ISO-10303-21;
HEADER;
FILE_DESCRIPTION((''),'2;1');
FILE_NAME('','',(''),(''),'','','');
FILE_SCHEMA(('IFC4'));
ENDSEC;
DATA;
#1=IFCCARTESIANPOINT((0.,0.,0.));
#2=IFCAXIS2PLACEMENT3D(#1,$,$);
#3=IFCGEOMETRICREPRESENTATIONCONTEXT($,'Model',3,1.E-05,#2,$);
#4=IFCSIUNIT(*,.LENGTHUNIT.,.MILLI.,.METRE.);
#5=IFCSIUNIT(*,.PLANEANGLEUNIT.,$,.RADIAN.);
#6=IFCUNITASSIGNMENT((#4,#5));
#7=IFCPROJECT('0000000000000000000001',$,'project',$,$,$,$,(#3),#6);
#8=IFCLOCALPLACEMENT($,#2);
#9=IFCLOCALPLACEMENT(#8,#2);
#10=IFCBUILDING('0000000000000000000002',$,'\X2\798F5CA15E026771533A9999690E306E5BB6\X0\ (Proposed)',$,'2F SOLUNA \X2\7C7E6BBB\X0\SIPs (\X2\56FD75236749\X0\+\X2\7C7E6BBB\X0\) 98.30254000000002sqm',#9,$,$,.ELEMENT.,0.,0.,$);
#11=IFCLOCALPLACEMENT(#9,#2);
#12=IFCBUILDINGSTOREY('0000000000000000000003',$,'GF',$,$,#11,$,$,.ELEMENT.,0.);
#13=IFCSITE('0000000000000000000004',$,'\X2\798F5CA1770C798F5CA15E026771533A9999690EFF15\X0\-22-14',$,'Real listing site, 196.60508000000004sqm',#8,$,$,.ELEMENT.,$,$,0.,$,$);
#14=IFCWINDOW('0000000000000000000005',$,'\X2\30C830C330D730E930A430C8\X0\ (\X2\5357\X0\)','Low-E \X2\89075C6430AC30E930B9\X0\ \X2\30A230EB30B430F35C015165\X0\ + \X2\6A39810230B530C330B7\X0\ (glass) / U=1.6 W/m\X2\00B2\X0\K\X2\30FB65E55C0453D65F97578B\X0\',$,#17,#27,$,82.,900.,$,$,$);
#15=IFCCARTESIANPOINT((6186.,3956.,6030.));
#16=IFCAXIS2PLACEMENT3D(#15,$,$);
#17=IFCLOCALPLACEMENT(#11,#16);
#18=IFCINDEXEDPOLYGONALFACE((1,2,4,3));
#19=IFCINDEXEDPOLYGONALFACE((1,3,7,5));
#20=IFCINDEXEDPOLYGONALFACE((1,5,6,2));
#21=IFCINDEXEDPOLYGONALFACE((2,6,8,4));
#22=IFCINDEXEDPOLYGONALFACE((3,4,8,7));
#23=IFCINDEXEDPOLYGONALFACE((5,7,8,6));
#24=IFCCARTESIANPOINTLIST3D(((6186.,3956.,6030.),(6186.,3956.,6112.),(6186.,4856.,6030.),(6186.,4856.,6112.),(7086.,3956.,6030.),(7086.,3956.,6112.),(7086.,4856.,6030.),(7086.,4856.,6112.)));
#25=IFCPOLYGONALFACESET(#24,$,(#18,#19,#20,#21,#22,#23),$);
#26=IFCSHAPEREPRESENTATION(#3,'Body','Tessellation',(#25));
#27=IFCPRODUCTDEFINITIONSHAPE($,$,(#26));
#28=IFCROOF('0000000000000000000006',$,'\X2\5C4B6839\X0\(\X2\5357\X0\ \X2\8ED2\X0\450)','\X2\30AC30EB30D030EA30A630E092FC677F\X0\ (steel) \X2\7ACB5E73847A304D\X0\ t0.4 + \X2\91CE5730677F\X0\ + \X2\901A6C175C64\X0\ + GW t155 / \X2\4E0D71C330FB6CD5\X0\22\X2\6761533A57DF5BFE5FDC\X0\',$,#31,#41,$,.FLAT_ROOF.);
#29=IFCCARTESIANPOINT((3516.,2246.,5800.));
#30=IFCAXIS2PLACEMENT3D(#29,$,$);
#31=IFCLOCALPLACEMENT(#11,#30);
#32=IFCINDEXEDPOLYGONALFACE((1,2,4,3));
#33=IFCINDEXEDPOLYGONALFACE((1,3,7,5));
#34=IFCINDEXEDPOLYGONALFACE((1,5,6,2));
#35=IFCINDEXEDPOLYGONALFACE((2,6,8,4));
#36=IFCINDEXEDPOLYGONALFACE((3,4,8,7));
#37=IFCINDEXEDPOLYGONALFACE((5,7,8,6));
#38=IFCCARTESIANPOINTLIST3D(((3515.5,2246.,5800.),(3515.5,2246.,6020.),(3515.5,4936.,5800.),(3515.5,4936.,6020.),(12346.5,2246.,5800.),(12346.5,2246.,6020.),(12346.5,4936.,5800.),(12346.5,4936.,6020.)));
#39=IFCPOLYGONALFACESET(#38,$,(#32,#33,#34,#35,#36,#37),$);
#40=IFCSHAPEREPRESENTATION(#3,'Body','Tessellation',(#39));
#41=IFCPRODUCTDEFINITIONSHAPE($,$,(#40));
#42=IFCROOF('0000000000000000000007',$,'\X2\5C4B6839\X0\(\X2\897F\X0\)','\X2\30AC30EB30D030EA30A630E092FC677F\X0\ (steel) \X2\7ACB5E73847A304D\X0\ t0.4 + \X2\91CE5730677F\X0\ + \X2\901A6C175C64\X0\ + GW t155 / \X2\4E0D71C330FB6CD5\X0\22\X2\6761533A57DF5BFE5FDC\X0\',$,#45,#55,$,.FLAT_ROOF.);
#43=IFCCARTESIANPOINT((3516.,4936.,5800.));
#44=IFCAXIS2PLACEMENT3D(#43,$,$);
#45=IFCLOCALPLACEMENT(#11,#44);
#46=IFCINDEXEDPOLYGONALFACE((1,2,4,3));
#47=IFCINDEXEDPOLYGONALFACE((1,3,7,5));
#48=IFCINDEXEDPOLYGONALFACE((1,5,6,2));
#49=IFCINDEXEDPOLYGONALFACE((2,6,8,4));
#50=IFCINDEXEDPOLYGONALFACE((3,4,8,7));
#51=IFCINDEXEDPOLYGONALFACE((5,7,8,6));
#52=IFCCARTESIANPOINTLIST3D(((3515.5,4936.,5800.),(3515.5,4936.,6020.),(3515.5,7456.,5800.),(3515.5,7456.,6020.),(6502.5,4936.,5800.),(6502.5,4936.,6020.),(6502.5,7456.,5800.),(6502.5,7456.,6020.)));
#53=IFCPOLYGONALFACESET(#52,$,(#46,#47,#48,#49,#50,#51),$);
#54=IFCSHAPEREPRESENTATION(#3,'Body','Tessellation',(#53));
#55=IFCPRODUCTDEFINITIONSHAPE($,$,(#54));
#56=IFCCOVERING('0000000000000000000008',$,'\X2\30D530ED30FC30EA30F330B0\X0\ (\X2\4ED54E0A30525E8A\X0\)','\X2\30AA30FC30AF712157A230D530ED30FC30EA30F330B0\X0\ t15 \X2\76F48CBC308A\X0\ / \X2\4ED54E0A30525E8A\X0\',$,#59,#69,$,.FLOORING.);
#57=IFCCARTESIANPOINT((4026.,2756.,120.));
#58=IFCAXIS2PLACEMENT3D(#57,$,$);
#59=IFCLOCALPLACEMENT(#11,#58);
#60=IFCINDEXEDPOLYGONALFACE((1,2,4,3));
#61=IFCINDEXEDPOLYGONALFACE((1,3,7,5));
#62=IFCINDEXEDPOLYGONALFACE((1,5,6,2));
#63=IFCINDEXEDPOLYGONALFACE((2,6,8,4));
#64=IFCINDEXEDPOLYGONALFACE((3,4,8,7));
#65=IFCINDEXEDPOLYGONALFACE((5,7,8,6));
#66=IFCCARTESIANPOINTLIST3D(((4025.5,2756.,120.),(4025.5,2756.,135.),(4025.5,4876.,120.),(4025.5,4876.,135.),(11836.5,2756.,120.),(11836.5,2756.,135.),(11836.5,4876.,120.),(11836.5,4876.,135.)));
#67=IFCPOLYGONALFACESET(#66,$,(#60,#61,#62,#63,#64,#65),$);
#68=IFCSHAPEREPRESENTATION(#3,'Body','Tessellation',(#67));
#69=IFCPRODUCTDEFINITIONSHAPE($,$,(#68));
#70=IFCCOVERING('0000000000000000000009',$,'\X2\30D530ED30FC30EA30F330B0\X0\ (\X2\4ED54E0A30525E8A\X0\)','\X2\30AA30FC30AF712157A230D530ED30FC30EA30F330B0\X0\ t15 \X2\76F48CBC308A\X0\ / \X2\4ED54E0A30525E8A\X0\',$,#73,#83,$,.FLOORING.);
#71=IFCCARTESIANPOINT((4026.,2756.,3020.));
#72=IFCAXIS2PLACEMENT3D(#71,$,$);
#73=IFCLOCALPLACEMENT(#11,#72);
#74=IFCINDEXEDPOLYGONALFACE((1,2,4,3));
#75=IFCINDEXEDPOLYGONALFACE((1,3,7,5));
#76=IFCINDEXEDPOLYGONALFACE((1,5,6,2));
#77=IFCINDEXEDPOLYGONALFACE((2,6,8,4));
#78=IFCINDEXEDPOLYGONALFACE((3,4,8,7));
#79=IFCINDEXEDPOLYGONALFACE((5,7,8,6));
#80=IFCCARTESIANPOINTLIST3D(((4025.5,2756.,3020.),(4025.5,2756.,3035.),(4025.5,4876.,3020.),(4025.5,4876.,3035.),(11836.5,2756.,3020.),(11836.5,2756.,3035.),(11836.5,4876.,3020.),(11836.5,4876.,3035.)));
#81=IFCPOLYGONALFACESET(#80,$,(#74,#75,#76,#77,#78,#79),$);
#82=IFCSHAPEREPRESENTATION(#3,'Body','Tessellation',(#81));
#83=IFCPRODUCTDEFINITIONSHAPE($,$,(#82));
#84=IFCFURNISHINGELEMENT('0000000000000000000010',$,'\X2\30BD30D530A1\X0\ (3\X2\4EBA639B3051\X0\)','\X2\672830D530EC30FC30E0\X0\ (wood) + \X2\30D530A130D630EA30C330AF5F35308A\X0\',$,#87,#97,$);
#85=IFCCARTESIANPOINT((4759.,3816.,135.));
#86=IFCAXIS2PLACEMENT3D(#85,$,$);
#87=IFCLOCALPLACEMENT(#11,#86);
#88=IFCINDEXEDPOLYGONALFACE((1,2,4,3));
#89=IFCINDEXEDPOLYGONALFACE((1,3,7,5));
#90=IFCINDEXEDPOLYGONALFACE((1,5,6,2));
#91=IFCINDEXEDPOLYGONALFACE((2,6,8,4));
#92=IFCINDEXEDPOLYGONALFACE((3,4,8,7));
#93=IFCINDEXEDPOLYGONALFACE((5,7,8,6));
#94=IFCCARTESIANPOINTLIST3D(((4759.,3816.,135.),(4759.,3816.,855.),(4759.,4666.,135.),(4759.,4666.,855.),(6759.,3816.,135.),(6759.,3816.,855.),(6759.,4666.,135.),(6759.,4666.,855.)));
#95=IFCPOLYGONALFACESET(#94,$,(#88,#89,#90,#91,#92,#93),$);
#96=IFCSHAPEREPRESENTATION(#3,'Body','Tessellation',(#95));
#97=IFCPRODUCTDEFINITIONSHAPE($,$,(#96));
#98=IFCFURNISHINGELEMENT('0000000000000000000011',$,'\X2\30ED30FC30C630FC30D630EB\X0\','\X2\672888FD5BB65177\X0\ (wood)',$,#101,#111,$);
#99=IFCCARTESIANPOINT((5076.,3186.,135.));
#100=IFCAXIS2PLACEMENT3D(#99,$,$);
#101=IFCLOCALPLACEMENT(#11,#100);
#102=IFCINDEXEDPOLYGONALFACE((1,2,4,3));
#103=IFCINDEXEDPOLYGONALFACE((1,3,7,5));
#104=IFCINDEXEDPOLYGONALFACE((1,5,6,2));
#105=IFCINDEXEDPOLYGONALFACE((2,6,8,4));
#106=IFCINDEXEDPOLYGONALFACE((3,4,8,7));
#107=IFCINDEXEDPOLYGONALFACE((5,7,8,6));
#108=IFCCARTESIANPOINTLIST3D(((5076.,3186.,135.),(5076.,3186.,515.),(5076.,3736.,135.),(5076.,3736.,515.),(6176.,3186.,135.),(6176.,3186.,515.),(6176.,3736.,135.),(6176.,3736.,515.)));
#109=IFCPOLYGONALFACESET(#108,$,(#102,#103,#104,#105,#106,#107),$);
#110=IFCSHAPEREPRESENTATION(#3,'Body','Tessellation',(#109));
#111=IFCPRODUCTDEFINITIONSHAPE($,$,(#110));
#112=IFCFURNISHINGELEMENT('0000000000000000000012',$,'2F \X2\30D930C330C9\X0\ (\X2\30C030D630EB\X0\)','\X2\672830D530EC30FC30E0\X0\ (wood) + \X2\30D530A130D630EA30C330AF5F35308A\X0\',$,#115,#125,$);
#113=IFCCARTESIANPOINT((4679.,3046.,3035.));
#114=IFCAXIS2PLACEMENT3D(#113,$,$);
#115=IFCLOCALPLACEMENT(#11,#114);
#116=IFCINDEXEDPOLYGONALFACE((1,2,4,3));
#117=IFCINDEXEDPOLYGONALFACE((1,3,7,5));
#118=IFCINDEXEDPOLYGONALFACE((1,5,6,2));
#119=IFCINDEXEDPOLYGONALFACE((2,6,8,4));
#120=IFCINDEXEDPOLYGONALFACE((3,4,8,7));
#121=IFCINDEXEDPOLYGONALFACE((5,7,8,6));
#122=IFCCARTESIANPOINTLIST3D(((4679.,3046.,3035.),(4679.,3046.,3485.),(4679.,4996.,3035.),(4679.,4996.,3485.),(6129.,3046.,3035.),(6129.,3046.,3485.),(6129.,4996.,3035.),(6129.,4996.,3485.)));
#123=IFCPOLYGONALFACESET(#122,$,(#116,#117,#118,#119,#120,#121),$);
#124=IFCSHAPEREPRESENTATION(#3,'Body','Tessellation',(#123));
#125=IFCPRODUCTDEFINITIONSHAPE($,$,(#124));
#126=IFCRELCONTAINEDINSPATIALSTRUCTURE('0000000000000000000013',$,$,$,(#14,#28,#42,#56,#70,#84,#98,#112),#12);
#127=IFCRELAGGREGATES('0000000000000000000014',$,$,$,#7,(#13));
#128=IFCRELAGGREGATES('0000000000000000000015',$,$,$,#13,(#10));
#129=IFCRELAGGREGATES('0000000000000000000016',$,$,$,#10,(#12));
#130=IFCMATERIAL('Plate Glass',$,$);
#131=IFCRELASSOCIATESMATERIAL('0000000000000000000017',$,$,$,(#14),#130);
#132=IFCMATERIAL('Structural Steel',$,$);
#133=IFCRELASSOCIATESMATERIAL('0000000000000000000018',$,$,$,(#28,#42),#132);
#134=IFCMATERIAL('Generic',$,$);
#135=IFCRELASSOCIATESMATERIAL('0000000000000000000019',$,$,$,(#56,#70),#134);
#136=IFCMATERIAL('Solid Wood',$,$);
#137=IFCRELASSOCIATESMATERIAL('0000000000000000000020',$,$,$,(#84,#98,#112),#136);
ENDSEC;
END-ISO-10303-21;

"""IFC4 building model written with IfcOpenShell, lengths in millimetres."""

from ifc_helpers import new_model, si_unit, frame, frame_2d, origin, place, context, project, spatial, rectangle, extrude, material, element, save


model = new_model("IFC4")

# Units and contexts
model_context = context("Model", 3, precision=1e-05, world=origin())
ifc_project = project(units=[si_unit("LENGTHUNIT", "METRE", prefix="MILLI"), si_unit("PLANEANGLEUNIT", "RADIAN")], contexts=[model_context])

# Site, building, storey
site_placement = place(None, origin())
site = spatial("IfcSite", under=ifc_project, at=site_placement, Name="福岡県福岡市東区香椎５-22-14", ObjectType="Real listing site, 196.60508000000004sqm", CompositionType="ELEMENT", RefElevation=0.0)
building_placement = place(site_placement, origin())
building = spatial("IfcBuilding", under=site, at=building_placement, Name="福岡市東区香椎の家 (Proposed)", ObjectType="2F SOLUNA 籾殻SIPs (国産杉+籾殻) 98.30254000000002sqm", CompositionType="ELEMENT", ElevationOfRefHeight=0.0, ElevationOfTerrain=0.0)
storey_placement = place(building_placement, origin())
storey = spatial("IfcBuildingStorey", under=building, at=storey_placement, Name="GF", CompositionType="ELEMENT", Elevation=0.0)

# Shared definitions
ifc_material_1 = material(Name="Solid Wood")

# Shared definitions
ifc_material_2 = material(Name="Plate Glass")

# Window
window_1_placement = place(storey_placement, frame((6186.0, 3956.0, 6030.0)))
element("IfcWindow", 1, at=window_1_placement, inside=storey, material=ifc_material_2, Name="トップライト (南)", Description="Low-E 複層ガラス アルゴン封入 + 樹脂サッシ (glass) / U=1.6 W/m²K・日射取得型", OverallHeight=82.0, OverallWidth=900.0, context=model_context, shape_type="SweptSolid", body=[
    extrude(rectangle(XDim=900.0, YDim=900.0, at=frame_2d((450.0, 450.0))), frame((6186.0, 3956.0, 6030.0)), (0.0, 0.0, 1.0), 82.0),
])

# Roofs
ifc_material_3 = material(Name="Structural Steel")
roof_1_placement = place(storey_placement, frame((3516.0, 2246.0, 5800.0)))
element("IfcRoof", 2, at=roof_1_placement, inside=storey, material=ifc_material_3, Name="屋根(南 軒450)", Description="ガルバリウム鋼板 (steel) 立平葺き t0.4 + 野地板 + 通気層 + GW t155 / 不燃・法22条区域対応", PredefinedType="FLAT_ROOF", context=model_context, shape_type="SweptSolid", body=[
    extrude(rectangle(XDim=8831.0, YDim=2690.0, at=frame_2d((4415.0, 1345.0))), frame((3516.0, 2246.0, 5800.0)), (0.0, 0.0, 1.0), 220.0),
])
roof_2_placement = place(storey_placement, frame((3516.0, 4936.0, 5800.0)))
element("IfcRoof", 3, at=roof_2_placement, inside=storey, material=ifc_material_3, Name="屋根(西)", Description="ガルバリウム鋼板 (steel) 立平葺き t0.4 + 野地板 + 通気層 + GW t155 / 不燃・法22条区域対応", PredefinedType="FLAT_ROOF", context=model_context, shape_type="SweptSolid", body=[
    extrude(rectangle(XDim=2987.0, YDim=2520.0, at=frame_2d((1493.0, 1260.0))), frame((3516.0, 4936.0, 5800.0)), (0.0, 0.0, 1.0), 220.0),
])

# Coverings
ifc_material_4 = material(Name="Generic")
covering_1_placement = place(storey_placement, frame((4026.0, 2756.0, 120.0)))
element("IfcCovering", 4, at=covering_1_placement, inside=storey, material=ifc_material_4, Name="フローリング (仕上げ床)", Description="オーク無垢フローリング t15 直貼り / 仕上げ床", PredefinedType="FLOORING", context=model_context, shape_type="SweptSolid", body=[
    extrude(rectangle(XDim=7811.0, YDim=2120.0, at=frame_2d((3905.0, 1060.0))), frame((4026.0, 2756.0, 120.0)), (0.0, 0.0, 1.0), 15.0),
])
covering_2_placement = place(storey_placement, frame((4026.0, 2756.0, 3020.0)))
element("IfcCovering", 5, at=covering_2_placement, inside=storey, material=ifc_material_4, Name="フローリング (仕上げ床)", Description="オーク無垢フローリング t15 直貼り / 仕上げ床", PredefinedType="FLOORING", context=model_context, shape_type="SweptSolid", body=[
    extrude(rectangle(XDim=7811.0, YDim=2120.0, at=frame_2d((3905.0, 1060.0))), frame((4026.0, 2756.0, 3020.0)), (0.0, 0.0, 1.0), 15.0),
])

# Furnishing elements
furnishing_1_placement = place(storey_placement, frame((4759.0, 3816.0, 135.0)))
element("IfcFurnishingElement", 6, at=furnishing_1_placement, inside=storey, material=ifc_material_1, Name="ソファ (3人掛け)", Description="木フレーム (wood) + ファブリック張り", context=model_context, shape_type="SweptSolid", body=[
    extrude(rectangle(XDim=2000.0, YDim=850.0, at=frame_2d((1000.0, 425.0))), frame((4759.0, 3816.0, 135.0)), (0.0, 0.0, 1.0), 720.0),
])
furnishing_2_placement = place(storey_placement, frame((5076.0, 3186.0, 135.0)))
element("IfcFurnishingElement", 7, at=furnishing_2_placement, inside=storey, material=ifc_material_1, Name="ローテーブル", Description="木製家具 (wood)", context=model_context, shape_type="SweptSolid", body=[
    extrude(rectangle(XDim=1100.0, YDim=550.0, at=frame_2d((550.0, 275.0))), frame((5076.0, 3186.0, 135.0)), (0.0, 0.0, 1.0), 380.0),
])
furnishing_3_placement = place(storey_placement, frame((4679.0, 3046.0, 3035.0)))
element("IfcFurnishingElement", 8, at=furnishing_3_placement, inside=storey, material=ifc_material_1, Name="2F ベッド (ダブル)", Description="木フレーム (wood) + ファブリック張り", context=model_context, shape_type="SweptSolid", body=[
    extrude(rectangle(XDim=1450.0, YDim=1950.0, at=frame_2d((725.0, 975.0))), frame((4679.0, 3046.0, 3035.0)), (0.0, 0.0, 1.0), 450.0),
])

save(model, "model.ifc")
